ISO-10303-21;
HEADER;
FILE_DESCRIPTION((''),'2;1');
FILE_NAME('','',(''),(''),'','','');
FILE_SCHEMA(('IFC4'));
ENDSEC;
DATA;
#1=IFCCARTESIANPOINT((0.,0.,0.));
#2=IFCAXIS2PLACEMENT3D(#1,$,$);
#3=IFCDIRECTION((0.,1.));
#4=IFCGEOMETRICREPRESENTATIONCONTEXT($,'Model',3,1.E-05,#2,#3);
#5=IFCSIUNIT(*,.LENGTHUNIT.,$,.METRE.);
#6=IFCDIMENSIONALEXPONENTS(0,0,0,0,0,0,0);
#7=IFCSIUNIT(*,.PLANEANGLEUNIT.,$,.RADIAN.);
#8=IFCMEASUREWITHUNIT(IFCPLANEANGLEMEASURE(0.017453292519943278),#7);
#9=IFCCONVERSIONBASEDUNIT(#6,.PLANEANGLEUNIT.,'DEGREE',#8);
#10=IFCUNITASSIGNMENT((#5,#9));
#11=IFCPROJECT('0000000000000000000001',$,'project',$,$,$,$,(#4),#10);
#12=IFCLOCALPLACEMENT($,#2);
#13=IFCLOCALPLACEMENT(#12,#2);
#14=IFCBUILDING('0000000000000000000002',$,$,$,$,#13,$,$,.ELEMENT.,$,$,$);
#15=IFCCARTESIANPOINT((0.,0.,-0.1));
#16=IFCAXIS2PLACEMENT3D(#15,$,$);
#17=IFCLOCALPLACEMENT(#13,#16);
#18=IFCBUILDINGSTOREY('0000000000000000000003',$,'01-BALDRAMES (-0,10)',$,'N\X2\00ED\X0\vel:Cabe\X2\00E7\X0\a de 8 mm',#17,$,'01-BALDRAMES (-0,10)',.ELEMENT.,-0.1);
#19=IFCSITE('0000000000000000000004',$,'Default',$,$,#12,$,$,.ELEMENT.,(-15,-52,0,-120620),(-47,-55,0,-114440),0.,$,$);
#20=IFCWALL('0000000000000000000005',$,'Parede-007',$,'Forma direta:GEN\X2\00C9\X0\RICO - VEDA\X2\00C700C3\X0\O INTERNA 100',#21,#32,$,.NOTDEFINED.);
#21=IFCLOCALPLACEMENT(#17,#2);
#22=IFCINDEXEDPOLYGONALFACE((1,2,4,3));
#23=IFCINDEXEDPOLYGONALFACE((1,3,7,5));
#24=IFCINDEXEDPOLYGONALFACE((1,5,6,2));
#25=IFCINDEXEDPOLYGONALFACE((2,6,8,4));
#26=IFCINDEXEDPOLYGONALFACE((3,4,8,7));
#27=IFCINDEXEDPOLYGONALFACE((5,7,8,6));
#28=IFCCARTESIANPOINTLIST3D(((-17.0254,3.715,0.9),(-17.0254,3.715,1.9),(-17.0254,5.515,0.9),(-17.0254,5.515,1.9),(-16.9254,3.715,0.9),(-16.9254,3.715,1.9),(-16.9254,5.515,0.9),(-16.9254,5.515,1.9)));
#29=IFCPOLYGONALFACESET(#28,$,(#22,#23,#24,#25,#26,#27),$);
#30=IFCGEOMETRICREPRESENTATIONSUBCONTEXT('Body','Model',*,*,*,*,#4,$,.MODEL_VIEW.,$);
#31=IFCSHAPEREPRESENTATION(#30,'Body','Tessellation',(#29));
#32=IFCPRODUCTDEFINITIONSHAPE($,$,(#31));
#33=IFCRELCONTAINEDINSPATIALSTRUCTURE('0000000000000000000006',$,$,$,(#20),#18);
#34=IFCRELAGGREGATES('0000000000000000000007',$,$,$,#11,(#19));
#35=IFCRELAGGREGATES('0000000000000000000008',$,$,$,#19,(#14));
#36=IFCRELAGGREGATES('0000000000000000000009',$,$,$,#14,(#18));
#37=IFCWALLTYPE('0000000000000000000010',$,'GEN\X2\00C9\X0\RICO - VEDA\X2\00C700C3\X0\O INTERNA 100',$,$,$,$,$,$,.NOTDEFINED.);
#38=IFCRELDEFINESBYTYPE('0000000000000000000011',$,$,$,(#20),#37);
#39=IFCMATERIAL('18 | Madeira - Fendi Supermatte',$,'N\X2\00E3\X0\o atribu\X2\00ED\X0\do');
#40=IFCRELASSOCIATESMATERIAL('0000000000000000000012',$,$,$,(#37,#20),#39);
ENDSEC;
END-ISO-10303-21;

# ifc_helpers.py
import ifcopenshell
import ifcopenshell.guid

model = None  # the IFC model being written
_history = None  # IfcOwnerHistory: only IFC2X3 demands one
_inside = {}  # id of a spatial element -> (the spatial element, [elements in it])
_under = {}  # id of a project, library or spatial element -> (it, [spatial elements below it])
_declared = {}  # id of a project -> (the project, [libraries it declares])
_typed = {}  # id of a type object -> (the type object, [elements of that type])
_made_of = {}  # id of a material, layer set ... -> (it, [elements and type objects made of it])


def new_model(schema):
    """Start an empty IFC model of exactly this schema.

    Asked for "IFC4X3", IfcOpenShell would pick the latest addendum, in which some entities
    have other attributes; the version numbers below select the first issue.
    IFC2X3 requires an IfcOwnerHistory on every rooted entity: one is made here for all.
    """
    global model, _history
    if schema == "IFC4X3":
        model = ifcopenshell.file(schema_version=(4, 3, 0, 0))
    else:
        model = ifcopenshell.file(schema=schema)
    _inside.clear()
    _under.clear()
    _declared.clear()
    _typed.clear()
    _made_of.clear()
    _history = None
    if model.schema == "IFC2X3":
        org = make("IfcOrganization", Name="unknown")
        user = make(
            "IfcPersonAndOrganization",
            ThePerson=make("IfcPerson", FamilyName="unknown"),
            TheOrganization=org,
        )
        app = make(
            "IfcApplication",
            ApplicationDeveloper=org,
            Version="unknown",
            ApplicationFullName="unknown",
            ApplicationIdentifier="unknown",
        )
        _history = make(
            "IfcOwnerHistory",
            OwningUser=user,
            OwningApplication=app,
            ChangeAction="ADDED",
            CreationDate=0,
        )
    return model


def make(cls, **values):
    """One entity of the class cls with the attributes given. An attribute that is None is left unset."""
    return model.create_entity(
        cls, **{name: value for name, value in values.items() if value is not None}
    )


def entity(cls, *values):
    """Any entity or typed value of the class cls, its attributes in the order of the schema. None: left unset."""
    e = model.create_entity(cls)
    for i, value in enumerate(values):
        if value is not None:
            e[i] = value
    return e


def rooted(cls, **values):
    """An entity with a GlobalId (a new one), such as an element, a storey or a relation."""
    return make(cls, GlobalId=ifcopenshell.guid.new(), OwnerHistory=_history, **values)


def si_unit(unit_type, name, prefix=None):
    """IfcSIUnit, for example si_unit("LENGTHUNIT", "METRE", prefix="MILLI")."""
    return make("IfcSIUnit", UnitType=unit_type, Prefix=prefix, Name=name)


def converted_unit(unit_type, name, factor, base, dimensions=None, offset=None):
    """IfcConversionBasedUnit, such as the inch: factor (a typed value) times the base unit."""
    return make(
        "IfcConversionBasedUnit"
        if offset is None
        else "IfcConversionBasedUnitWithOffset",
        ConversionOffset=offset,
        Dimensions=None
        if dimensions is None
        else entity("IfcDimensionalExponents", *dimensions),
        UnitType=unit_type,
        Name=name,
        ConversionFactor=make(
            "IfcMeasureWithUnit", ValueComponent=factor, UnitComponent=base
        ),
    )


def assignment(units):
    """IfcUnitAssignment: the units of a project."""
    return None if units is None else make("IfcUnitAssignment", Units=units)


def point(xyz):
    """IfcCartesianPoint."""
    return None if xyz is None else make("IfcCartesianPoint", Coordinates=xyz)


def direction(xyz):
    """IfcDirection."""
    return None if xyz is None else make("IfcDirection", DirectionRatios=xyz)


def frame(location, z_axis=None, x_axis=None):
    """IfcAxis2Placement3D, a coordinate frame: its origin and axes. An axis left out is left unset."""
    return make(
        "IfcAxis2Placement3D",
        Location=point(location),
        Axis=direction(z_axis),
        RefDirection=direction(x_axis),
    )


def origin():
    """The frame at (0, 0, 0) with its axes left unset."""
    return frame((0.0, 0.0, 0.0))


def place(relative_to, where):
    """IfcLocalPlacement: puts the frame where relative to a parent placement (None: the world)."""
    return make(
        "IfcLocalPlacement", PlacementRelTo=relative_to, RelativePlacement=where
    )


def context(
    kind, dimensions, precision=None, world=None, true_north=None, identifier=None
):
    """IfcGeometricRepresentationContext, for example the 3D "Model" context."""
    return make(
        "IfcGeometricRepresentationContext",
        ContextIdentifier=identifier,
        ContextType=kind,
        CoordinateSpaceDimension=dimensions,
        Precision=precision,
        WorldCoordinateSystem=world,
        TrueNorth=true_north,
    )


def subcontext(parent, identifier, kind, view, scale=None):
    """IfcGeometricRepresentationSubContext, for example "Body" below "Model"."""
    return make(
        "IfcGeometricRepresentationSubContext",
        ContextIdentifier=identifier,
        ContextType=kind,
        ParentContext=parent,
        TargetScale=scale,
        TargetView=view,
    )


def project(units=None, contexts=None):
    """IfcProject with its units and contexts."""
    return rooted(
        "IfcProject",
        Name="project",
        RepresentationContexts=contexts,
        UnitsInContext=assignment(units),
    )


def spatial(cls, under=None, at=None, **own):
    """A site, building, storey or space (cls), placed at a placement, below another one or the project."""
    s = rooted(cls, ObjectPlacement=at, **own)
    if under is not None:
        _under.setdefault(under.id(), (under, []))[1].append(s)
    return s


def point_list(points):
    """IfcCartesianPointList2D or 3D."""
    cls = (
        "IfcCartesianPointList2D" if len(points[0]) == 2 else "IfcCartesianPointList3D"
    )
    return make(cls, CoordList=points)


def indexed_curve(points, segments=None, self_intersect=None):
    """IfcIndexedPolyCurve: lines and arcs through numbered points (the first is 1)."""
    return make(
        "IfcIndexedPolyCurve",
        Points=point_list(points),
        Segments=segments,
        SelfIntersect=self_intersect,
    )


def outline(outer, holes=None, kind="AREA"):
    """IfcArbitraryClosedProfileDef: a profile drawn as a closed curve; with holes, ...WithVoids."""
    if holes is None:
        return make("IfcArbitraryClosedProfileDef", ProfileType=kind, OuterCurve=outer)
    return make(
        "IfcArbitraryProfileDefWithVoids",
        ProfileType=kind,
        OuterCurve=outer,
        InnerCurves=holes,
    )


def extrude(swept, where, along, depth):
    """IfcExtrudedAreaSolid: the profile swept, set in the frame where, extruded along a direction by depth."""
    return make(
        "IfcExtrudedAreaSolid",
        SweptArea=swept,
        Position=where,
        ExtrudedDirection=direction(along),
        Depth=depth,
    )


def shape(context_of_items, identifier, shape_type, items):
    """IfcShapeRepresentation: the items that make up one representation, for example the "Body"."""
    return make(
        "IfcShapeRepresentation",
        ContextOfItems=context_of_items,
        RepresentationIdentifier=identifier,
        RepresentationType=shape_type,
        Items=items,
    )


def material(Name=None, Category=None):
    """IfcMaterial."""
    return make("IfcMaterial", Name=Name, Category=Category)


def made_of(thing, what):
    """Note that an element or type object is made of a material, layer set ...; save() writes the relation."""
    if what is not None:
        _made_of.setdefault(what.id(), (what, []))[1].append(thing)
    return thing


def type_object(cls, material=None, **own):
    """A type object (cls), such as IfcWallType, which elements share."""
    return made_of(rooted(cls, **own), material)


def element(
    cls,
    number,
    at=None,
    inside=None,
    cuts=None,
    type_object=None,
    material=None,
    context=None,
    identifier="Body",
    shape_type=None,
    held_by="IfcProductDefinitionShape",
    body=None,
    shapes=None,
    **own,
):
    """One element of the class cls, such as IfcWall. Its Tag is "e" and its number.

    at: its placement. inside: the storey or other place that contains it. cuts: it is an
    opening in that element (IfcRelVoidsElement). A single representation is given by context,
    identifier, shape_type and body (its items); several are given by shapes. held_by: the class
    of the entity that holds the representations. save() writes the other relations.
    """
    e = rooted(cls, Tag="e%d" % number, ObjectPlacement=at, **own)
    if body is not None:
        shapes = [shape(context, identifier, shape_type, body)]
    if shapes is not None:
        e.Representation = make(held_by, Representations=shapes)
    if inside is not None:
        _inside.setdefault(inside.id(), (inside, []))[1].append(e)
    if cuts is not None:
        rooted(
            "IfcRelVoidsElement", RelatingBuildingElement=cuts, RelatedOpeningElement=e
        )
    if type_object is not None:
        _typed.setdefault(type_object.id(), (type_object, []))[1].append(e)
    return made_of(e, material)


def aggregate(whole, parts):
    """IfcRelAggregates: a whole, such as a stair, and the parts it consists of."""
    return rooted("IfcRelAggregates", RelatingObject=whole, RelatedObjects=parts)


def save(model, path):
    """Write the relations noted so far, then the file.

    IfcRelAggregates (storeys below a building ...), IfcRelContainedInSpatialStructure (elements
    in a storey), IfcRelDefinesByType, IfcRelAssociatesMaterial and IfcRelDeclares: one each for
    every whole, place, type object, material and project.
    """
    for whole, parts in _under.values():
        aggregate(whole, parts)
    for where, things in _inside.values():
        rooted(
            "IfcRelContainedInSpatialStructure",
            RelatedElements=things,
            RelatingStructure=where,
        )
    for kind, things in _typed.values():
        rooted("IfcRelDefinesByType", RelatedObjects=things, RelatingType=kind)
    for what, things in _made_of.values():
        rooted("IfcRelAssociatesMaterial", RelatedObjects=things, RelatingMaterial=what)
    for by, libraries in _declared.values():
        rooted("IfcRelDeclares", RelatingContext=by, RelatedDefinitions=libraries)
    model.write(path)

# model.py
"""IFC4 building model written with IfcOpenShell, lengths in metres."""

from ifc_helpers import new_model, entity, si_unit, converted_unit, direction, frame, origin, place, context, subcontext, project, spatial, indexed_curve, outline, extrude, material, type_object, element, save


model = new_model("IFC4")

# Units and contexts
model_context = context("Model", 3, precision=1e-05, world=origin(), true_north=direction((0.0, 1.0)))
body_context = subcontext(model_context, "Body", "Model", "MODEL_VIEW")
ifc_project = project(units=[si_unit("LENGTHUNIT", "METRE"), converted_unit("PLANEANGLEUNIT", "DEGREE", entity("IfcPlaneAngleMeasure", 0.017453292519943278), si_unit("PLANEANGLEUNIT", "RADIAN"), dimensions=[0, 0, 0, 0, 0, 0, 0])], contexts=[model_context])

# Site, building, storey
site_placement = place(None, origin())
site = spatial("IfcSite", under=ifc_project, at=site_placement, Name="Default", CompositionType="ELEMENT", RefLatitude=(-15, -52, 0, -120620), RefLongitude=(-47, -55, 0, -114440), RefElevation=0.0)
building_placement = place(site_placement, origin())
building = spatial("IfcBuilding", under=site, at=building_placement, CompositionType="ELEMENT")
storey_placement = place(building_placement, frame((0.0, 0.0, -0.1)))
storey = spatial("IfcBuildingStorey", under=building, at=storey_placement, Name="01-BALDRAMES (-0,10)", ObjectType="Nível:Cabeça de 8 mm", LongName="01-BALDRAMES (-0,10)", CompositionType="ELEMENT", Elevation=-0.1)

# Wall
ifc_material_1 = material(Name="18 | Madeira - Fendi Supermatte", Category="Não atribuído")
wall_type_1 = type_object("IfcWallType", Name="GENÉRICO - VEDAÇÃO INTERNA 100", PredefinedType="NOTDEFINED", material=ifc_material_1)
wall_1_placement = place(storey_placement, frame((-17.0254, 3.715, 0.9), z_axis=(0.0, 0.0, 1.0), x_axis=(0.0, 1.0, 0.0)))
element("IfcWall", 1, at=wall_1_placement, inside=storey, type_object=wall_type_1, material=ifc_material_1, Name="Parede-007", ObjectType="Forma direta:GENÉRICO - VEDAÇÃO INTERNA 100", PredefinedType="NOTDEFINED", context=body_context, shape_type="SweptSolid", body=[
    extrude(outline(indexed_curve([(-0.05, -0.9), (0.05, -0.9), (0.05, 0.9), (-0.05, 0.9), (-0.05, -0.9)], self_intersect=False)), frame((0.9, -0.05, 0.0), z_axis=(0.0, 0.0, 1.0), x_axis=(-0.000013, -1.0, 0.0)), (0.0, 0.0, 1.0), 1.0),
])

save(model, "model.ifc")
